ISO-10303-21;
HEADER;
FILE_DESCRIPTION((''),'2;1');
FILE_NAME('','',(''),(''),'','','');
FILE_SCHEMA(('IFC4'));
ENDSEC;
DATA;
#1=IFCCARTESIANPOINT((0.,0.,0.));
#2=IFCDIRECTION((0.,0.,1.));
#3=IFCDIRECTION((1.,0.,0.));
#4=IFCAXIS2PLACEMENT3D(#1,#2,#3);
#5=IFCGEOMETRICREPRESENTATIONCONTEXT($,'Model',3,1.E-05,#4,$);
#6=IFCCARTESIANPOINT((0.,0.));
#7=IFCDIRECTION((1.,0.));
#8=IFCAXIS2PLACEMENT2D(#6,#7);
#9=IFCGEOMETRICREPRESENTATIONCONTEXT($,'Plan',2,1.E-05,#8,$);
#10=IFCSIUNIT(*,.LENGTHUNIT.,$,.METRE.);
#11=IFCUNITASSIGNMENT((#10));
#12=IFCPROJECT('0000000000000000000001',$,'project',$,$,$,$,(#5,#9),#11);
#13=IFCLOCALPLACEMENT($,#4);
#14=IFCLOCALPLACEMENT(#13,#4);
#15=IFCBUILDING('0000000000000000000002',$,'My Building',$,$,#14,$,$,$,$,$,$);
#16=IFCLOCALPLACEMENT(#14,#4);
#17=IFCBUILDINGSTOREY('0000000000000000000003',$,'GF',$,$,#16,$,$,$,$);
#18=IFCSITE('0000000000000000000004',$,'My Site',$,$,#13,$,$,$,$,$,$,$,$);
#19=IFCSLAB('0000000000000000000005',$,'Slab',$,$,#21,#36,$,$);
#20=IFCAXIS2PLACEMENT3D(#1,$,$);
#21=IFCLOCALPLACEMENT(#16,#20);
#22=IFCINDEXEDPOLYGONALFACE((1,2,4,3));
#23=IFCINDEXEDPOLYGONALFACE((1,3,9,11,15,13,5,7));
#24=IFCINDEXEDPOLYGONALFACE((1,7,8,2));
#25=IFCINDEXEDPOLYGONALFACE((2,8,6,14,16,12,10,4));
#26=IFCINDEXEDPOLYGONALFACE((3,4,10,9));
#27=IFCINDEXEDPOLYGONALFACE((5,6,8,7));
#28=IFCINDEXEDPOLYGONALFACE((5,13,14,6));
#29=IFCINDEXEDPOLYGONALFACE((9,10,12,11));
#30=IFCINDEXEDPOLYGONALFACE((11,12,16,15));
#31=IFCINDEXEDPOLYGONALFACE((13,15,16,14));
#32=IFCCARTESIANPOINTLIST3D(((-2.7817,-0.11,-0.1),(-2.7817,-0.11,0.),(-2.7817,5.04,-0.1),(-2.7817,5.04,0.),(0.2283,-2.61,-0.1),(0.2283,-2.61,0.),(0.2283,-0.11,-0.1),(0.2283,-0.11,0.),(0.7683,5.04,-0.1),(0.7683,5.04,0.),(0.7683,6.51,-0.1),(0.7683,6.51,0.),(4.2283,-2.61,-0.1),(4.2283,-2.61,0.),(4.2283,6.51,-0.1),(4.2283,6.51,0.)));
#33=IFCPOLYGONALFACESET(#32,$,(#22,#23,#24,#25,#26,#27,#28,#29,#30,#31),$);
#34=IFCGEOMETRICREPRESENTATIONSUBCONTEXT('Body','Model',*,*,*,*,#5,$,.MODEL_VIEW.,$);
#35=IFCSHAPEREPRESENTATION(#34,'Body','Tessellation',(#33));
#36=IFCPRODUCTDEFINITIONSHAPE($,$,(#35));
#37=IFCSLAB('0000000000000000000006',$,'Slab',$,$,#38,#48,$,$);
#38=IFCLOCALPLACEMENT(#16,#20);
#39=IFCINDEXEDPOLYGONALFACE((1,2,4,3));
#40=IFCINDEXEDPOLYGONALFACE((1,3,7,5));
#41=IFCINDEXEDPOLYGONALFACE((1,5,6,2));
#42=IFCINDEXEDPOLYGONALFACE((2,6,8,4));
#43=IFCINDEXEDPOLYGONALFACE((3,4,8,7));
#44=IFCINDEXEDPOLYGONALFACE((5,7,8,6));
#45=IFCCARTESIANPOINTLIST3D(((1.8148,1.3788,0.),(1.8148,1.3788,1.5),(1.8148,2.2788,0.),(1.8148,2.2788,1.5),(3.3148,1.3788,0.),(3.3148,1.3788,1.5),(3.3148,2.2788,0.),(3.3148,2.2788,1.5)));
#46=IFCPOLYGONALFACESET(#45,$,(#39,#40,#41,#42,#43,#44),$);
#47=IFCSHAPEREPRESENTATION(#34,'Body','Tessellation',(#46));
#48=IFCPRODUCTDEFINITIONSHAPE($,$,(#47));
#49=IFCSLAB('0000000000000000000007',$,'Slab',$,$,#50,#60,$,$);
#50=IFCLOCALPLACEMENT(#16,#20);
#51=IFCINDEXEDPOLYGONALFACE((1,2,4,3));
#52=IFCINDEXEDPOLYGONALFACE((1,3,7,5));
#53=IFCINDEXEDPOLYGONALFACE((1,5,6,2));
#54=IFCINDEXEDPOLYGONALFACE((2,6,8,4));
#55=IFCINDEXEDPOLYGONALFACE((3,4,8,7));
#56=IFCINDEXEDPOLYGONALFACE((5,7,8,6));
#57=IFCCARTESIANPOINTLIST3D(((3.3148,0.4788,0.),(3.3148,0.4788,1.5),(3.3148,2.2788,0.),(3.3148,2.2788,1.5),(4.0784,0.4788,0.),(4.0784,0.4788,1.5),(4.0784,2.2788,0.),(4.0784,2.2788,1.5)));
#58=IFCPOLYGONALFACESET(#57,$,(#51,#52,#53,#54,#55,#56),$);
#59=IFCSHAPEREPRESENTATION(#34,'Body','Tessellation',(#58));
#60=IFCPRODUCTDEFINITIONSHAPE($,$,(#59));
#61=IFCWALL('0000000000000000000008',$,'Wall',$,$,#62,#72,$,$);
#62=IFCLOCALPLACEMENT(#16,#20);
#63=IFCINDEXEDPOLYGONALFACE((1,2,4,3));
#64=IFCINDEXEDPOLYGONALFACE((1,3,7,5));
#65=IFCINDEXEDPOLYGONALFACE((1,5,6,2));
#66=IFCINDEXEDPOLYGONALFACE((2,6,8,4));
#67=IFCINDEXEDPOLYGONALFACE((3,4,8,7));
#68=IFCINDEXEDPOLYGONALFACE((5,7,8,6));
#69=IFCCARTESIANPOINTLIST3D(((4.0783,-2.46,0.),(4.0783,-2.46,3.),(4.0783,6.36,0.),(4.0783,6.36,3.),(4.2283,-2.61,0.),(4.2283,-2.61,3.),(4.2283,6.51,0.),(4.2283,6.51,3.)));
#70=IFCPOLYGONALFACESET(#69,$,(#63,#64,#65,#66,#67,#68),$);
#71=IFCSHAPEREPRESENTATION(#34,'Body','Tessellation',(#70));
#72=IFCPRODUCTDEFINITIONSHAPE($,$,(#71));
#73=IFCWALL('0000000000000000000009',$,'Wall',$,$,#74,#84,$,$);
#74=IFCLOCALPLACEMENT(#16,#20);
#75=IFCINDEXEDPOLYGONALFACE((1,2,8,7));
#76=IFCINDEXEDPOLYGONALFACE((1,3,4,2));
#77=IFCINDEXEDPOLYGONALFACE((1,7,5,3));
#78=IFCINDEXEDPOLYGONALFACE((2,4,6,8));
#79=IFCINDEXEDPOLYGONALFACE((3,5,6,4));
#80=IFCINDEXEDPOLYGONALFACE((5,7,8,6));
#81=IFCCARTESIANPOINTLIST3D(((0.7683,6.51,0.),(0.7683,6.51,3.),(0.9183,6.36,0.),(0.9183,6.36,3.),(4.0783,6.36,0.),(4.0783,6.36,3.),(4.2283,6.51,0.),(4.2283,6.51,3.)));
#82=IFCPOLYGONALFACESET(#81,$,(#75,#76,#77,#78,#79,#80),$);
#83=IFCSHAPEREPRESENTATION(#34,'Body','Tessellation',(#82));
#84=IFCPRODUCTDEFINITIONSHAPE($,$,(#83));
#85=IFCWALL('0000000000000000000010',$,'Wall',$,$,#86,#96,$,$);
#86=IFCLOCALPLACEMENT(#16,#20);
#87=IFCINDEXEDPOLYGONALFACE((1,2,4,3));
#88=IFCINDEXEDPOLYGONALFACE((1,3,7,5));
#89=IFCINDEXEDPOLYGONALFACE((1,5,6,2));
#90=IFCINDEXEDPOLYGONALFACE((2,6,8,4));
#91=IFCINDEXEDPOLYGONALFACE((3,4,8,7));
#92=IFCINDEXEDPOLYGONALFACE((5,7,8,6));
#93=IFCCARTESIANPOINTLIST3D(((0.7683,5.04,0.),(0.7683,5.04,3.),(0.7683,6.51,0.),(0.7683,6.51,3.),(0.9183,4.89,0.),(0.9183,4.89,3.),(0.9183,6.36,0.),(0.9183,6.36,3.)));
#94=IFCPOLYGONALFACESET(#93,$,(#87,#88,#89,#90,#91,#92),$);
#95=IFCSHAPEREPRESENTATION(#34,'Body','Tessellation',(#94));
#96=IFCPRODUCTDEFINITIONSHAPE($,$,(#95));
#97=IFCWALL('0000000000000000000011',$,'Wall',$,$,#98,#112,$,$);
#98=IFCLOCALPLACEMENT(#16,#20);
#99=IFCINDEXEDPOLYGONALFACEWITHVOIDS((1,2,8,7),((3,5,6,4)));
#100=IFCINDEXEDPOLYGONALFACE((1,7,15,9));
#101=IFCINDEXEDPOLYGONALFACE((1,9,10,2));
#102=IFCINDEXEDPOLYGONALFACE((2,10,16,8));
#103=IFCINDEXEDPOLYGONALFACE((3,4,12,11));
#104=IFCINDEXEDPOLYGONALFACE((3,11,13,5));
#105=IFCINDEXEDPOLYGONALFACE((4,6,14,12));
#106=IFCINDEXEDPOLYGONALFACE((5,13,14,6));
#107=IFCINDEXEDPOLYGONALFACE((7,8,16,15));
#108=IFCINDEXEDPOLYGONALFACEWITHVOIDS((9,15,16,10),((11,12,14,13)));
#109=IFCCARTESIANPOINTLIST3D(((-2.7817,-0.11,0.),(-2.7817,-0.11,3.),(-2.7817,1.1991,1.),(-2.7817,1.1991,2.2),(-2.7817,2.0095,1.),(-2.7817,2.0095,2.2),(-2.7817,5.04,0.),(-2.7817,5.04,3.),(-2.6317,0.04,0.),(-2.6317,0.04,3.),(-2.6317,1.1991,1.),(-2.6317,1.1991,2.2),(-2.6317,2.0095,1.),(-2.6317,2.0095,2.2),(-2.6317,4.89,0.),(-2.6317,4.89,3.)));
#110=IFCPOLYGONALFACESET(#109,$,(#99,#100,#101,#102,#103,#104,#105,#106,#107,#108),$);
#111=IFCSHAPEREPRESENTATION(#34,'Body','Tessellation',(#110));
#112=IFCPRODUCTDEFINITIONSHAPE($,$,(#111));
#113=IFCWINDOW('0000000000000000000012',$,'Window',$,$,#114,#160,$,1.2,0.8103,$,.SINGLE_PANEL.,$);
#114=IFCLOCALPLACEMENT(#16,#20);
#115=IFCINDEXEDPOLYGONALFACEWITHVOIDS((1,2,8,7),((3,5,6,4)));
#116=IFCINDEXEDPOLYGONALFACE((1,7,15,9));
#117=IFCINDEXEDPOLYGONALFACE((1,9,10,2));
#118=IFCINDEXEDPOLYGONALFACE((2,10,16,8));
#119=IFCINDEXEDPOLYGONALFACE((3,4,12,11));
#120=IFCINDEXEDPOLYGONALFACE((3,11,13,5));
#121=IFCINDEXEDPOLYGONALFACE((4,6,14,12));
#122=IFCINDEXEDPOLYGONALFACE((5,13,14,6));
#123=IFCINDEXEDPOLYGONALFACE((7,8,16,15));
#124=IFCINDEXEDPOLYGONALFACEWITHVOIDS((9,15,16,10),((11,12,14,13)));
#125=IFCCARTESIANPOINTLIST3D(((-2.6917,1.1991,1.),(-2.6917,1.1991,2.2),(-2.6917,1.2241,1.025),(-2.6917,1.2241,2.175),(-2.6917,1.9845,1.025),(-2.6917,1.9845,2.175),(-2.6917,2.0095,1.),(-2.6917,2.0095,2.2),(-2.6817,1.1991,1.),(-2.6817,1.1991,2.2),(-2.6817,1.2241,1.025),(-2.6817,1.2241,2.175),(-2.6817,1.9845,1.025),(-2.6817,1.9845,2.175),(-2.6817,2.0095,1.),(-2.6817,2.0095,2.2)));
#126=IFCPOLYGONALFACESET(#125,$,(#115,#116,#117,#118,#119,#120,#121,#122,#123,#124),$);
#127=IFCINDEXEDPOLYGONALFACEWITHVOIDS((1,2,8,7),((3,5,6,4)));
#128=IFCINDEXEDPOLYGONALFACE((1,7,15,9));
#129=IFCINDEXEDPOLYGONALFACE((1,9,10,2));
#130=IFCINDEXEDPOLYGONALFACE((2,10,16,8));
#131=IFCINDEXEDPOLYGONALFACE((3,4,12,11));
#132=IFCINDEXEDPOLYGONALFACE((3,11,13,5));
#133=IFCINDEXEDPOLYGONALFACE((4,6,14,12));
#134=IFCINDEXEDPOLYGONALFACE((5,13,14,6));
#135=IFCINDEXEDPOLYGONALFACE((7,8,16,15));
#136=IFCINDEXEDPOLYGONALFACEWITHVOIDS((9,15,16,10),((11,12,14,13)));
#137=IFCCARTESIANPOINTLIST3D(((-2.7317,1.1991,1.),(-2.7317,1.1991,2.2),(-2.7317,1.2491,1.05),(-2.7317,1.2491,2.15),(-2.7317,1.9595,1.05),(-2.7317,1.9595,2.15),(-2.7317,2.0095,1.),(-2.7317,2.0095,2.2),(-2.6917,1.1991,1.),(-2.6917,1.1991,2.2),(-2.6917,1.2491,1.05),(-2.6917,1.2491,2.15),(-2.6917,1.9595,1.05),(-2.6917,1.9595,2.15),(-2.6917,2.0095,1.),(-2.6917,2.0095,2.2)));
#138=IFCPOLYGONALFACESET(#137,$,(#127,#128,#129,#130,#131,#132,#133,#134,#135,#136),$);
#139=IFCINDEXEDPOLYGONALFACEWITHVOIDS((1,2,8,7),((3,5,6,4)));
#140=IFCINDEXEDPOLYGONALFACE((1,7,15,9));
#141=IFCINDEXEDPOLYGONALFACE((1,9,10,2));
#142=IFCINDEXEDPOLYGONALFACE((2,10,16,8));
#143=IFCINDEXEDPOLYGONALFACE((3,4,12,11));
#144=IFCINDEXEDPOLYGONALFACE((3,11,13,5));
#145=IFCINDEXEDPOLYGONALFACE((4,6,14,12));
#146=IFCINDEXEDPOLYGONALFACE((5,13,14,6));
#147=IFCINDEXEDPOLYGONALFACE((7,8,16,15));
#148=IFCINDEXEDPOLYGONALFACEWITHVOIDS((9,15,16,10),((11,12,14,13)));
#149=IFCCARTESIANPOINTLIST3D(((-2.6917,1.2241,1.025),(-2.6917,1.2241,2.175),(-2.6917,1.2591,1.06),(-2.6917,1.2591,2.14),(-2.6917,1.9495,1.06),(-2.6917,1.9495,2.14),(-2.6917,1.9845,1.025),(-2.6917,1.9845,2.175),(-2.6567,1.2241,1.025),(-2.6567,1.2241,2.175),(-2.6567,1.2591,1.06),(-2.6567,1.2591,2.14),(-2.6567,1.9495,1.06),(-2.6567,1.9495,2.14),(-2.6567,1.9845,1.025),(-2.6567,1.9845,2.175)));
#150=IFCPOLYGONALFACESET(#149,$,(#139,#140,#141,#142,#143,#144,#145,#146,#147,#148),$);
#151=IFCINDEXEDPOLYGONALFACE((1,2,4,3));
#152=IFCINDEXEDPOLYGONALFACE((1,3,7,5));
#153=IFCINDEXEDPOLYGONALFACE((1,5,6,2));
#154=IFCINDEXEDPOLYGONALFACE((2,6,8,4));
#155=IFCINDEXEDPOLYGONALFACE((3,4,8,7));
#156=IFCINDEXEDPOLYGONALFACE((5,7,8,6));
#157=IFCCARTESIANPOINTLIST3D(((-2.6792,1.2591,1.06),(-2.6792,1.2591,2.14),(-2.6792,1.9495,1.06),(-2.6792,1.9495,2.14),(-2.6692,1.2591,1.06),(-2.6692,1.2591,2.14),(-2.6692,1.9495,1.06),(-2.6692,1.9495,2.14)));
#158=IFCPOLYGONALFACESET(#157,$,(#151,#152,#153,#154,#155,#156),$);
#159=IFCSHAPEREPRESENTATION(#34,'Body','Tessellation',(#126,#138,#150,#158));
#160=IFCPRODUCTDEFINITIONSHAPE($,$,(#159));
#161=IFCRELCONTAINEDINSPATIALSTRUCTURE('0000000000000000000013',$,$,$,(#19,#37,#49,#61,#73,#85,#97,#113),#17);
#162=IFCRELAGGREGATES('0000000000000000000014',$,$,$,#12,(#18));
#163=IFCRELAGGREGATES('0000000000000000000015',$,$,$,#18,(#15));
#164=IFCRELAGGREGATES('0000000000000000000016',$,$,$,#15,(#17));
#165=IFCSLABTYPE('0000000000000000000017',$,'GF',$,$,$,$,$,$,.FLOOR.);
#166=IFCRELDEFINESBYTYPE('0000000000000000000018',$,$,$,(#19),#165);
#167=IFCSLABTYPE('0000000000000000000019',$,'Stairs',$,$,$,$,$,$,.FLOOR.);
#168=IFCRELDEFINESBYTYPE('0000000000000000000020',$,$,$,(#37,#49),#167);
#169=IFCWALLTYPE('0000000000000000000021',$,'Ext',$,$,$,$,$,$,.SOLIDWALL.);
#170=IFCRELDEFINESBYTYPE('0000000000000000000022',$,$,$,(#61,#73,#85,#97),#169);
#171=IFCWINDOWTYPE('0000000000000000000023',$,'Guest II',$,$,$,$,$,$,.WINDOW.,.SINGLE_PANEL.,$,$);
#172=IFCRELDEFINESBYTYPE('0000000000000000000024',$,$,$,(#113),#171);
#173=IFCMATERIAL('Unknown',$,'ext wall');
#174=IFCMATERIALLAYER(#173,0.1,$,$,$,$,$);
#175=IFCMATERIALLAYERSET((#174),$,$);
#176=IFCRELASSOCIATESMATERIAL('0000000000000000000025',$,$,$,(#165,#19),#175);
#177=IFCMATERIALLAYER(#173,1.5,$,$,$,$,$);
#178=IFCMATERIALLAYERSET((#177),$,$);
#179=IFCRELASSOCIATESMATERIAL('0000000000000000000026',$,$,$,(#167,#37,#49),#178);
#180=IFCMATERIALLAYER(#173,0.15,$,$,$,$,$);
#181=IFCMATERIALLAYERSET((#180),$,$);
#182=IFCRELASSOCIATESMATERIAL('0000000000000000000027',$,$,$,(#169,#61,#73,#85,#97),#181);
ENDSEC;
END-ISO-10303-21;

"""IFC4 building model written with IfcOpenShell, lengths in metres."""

from ifc_helpers import new_model, entity, si_unit, frame, origin_with_axes, origin_2d_with_axis, place, context, subcontext, project, spatial, line, indexed_curve, outline, extrude, shape, source, transform, mapped, material, layer, layer_set, layer_usage, type_object, type_shapes, element, fill, save


model = new_model("IFC4")

# Units and contexts
model_context = context("Model", 3, precision=1e-05, world=origin_with_axes())
plan_context = context("Plan", 2, precision=1e-05, world=origin_2d_with_axis())
body_context_1 = subcontext(model_context, "Body", "Model", "MODEL_VIEW")
body_context_2 = subcontext(plan_context, "Body", "Plan", "PLAN_VIEW")
ifc_project = project(units=[si_unit("LENGTHUNIT", "METRE")], contexts=[model_context, plan_context])

# Site, building, storey
site_placement = place(None, origin_with_axes())
site = spatial("IfcSite", under=ifc_project, at=site_placement, Name="My Site")
building_placement = place(site_placement, origin_with_axes())
building = spatial("IfcBuilding", under=site, at=building_placement, Name="My Building")
storey_placement = place(building_placement, origin_with_axes())
storey = spatial("IfcBuildingStorey", under=building, at=storey_placement, Name="GF")

# Slabs
ifc_material = material(Name="Unknown", Category="ext wall")
ifc_layer_1 = layer(ifc_material, 0.1)
ifc_layer_set_1 = layer_set([ifc_layer_1])
ifc_layer_usage_1 = layer_usage(ifc_layer_set_1, "AXIS3", "POSITIVE", -0.1)
slab_type_1 = type_object("IfcSlabType", Name="GF", PredefinedType="FLOOR", material=ifc_layer_set_1)
slab_1_placement = place(storey_placement, frame((-2.7817, 5.04, 0.0), z_axis=(0.0, 0.0, 1.0), x_axis=(1.0, 0.0, 0.0)))
element("IfcSlab", 1, at=slab_1_placement, inside=storey, type_object=slab_type_1, material=ifc_layer_usage_1, Name="Slab", context=body_context_1, shape_type="SweptSolid", body=[
    extrude(outline(indexed_curve([(0.0, 0.0), (3.55, 0.0), (3.55, 1.47), (7.01, 1.47), (7.01, -7.65), (3.01, -7.65), (3.01, -5.15), (0.0, -5.15), (0.0, 0.0)])), frame((0.0, 0.0, -0.1), z_axis=(0.0, 0.0, 1.0), x_axis=(1.0, 0.0, 0.0)), (0.0, 0.0, 1.0), 0.1),
])
ifc_layer_2 = layer(ifc_material, 1.5)
ifc_layer_set_2 = layer_set([ifc_layer_2])
ifc_layer_usage_2 = layer_usage(ifc_layer_set_2, "AXIS3", "POSITIVE", -1.5)
slab_type_2 = type_object("IfcSlabType", Name="Stairs", PredefinedType="FLOOR", material=ifc_layer_set_2)
slab_2_placement = place(storey_placement, frame((3.3148, 2.2788, 1.5), z_axis=(0.0, 0.0, 1.0), x_axis=(1.0, 0.0, 0.0)))
element("IfcSlab", 2, at=slab_2_placement, inside=storey, type_object=slab_type_2, material=ifc_layer_usage_2, Name="Slab", context=body_context_1, shape_type="SweptSolid", body=[
    extrude(outline(indexed_curve([(0.0, 0.0), (0.0, -0.9), (-1.5, -0.9), (-1.5, 0.0), (0.0, 0.0)])), frame((0.0, 0.0, -1.5), z_axis=(0.0, 0.0, 1.0), x_axis=(1.0, 0.0, 0.0)), (0.0, 0.0, 1.0), 1.5),
])
ifc_layer_usage_3 = layer_usage(ifc_layer_set_2, "AXIS3", "POSITIVE", -1.5)
slab_3_placement = place(storey_placement, frame((3.3148, 0.4788, 1.5), z_axis=(0.0, 0.0, 1.0), x_axis=(1.0, 0.0, 0.0)))
element("IfcSlab", 3, at=slab_3_placement, inside=storey, type_object=slab_type_2, material=ifc_layer_usage_3, Name="Slab", context=body_context_1, shape_type="SweptSolid", body=[
    extrude(outline(indexed_curve([(0.0, 0.0), (0.7636, 0.0), (0.7636, 1.8), (0.0, 1.8), (0.0, 0.0)])), frame((0.0, 0.0, -1.5), z_axis=(0.0, 0.0, 1.0), x_axis=(1.0, 0.0, 0.0)), (0.0, 0.0, 1.0), 1.5),
])

# Shared definitions
ifc_layer_3 = layer(ifc_material, 0.15)
ifc_layer_set_3 = layer_set([ifc_layer_3])
wall_type_1 = type_object("IfcWallType", Name="Ext", PredefinedType="SOLIDWALL", material=ifc_layer_set_3)

# Walls
ifc_layer_usage_4 = layer_usage(ifc_layer_set_3, "AXIS2", "POSITIVE", 0.0)
wall_1_placement = place(storey_placement, frame((4.2283, -2.61, 0.0), z_axis=(0.0, 0.0, 1.0), x_axis=(0.0, 1.0, 0.0)))
element("IfcWall", 4, at=wall_1_placement, inside=storey, type_object=wall_type_1, material=ifc_layer_usage_4, Name="Wall", context=body_context_1, shape_type="SweptSolid", body=[
    extrude(outline(indexed_curve([(0.0, 0.0), (0.15, 0.15), (8.97, 0.15), (9.12, 0.0)], segments=[line(1, 2, 3, 4, 1)])), origin_with_axes(), (0.0, 0.0, 1.0), 3.0),
])
ifc_layer_usage_5 = layer_usage(ifc_layer_set_3, "AXIS2", "POSITIVE", 0.0)
wall_2_placement = place(storey_placement, frame((4.2283, 6.51, 0.0), z_axis=(0.0, 0.0, 1.0), x_axis=(-1.0, 0.0, 0.0)))
element("IfcWall", 5, at=wall_2_placement, inside=storey, type_object=wall_type_1, material=ifc_layer_usage_5, Name="Wall", context=body_context_1, shape_type="SweptSolid", body=[
    extrude(outline(indexed_curve([(0.0, 0.0), (0.15, 0.15), (3.31, 0.15), (3.46, 0.0)], segments=[line(1, 2, 3, 4, 1)])), origin_with_axes(), (0.0, 0.0, 1.0), 3.0),
])
ifc_layer_usage_6 = layer_usage(ifc_layer_set_3, "AXIS2", "POSITIVE", 0.0)
wall_3_placement = place(storey_placement, frame((0.7683, 6.51, 0.0), z_axis=(0.0, 0.0, 1.0), x_axis=(0.0, -1.0, 0.0)))
element("IfcWall", 6, at=wall_3_placement, inside=storey, type_object=wall_type_1, material=ifc_layer_usage_6, Name="Wall", context=body_context_1, shape_type="SweptSolid", body=[
    extrude(outline(indexed_curve([(0.0, 0.0), (0.15, 0.15), (1.62, 0.15), (1.47, 0.0)], segments=[line(1, 2, 3, 4, 1)])), origin_with_axes(), (0.0, 0.0, 1.0), 3.0),
])

# Wall, opening, window
ifc_layer_usage_7 = layer_usage(ifc_layer_set_3, "AXIS2", "POSITIVE", 0.0)
wall_4_placement = place(storey_placement, frame((-2.7817, 5.04, 0.0), z_axis=(0.0, 0.0, 1.0), x_axis=(0.0, -1.0, 0.0)))
wall_4 = element("IfcWall", 7, at=wall_4_placement, inside=storey, type_object=wall_type_1, material=ifc_layer_usage_7, Name="Wall", context=body_context_1, shape_type="SweptSolid", body=[
    extrude(outline(indexed_curve([(0.0, 0.0), (0.15, 0.15), (5.0, 0.15), (5.15, 0.0)], segments=[line(1, 2, 3, 4, 1)])), origin_with_axes(), (0.0, 0.0, 1.0), 3.0),
])
shared_shape_1 = source(origin_with_axes(), body_context_1, "Body", "SweptSolid", [
    extrude(outline(indexed_curve([(0.0, 0.0), (0.8103, 0.0), (0.8103, 1.2), (0.0, 1.2)], segments=[line(1, 2, 3, 4, 1)])), frame((0.0, -0.6, 0.0), z_axis=(0.0, -1.0, 0.0), x_axis=(1.0, 0.0, 0.0)), (0.0, 0.0, -1.0), 1.2),
])
opening_1_placement = place(wall_4_placement, frame((3.0305, 0.0, 1.0), z_axis=(0.0, 0.0, 1.0), x_axis=(1.0, 0.0, 0.0)))
opening_1 = element("IfcOpeningElement", 8, at=opening_1_placement, cuts=wall_4, PredefinedType="OPENING", context=body_context_1, shape_type="MappedRepresentation", body=[
    mapped(shared_shape_1, transform((0.0, 0.0, 0.0), x_axis=(1.0, 0.0, 0.0), y_axis=(0.0, 1.0, 0.0), z_axis=(0.0, 0.0, 1.0), scale=1.0)),
])
window_type_1 = type_object("IfcWindowType", Name="Guest II", PartitioningType="SINGLE_PANEL", PredefinedType="WINDOW")
shared_shape_2 = source(origin_with_axes(), body_context_1, "Body", "SweptSolid", [
    extrude(outline(indexed_curve([(0.0, 0.0), (0.8103, 0.0), (0.8103, 1.2), (0.0, 1.2)], segments=[line(1, 2, 3, 4, 1)]), holes=[indexed_curve([(0.025, 0.025), (0.7853, 0.025), (0.7853, 1.175), (0.025, 1.175)], segments=[line(1, 2, 3, 4, 1)])]), frame((0.0, 0.09, 0.0), z_axis=(0.0, -1.0, 0.0), x_axis=(1.0, 0.0, 0.0)), (0.0, 0.0, -1.0), 0.01),
    extrude(outline(indexed_curve([(0.0, 0.0), (0.8103, 0.0), (0.8103, 1.2), (0.0, 1.2)], segments=[line(1, 2, 3, 4, 1)]), holes=[indexed_curve([(0.05, 0.05), (0.7603, 0.05), (0.7603, 1.15), (0.05, 1.15)], segments=[line(1, 2, 3, 4, 1)])]), frame((0.0, 0.05, 0.0), z_axis=(0.0, -1.0, 0.0), x_axis=(1.0, 0.0, 0.0)), (0.0, 0.0, -1.0), 0.04),
    extrude(outline(indexed_curve([(0.0, 0.0), (0.7603, 0.0), (0.7603, 1.15), (0.0, 1.15)], segments=[line(1, 2, 3, 4, 1)]), holes=[indexed_curve([(0.035, 0.035), (0.7253, 0.035), (0.7253, 1.115), (0.035, 1.115)], segments=[line(1, 2, 3, 4, 1)])]), frame((0.025, 0.09, 0.025), z_axis=(0.0, -1.0, 0.0), x_axis=(1.0, 0.0, 0.0)), (0.0, 0.0, -1.0), 0.035),
    extrude(outline(indexed_curve([(0.035, 0.035), (0.7253, 0.035), (0.7253, 1.115), (0.035, 1.115)], segments=[line(1, 2, 3, 4, 1)])), frame((0.025, 0.1025, 0.025), z_axis=(0.0, -1.0, 0.0), x_axis=(1.0, 0.0, 0.0)), (0.0, 0.0, -1.0), 0.01),
])
shared_shape_3 = source(origin_with_axes(), body_context_2, "Body", "Curve2D", [
    entity("IfcIndexedPolyCurve", entity("IfcCartesianPointList2D", [[0.05, 0.05], [0.7603, 0.05]])),
    entity("IfcIndexedPolyCurve", entity("IfcCartesianPointList2D", [[0.0, 0.1], [0.025, 0.1], [0.025, 0.09], [0.05, 0.09], [0.05, 0.05], [0.0, 0.05]]), [entity("IfcLineIndex", [1, 2, 3, 4, 5, 6, 1])]),
    entity("IfcIndexedPolyCurve", entity("IfcCartesianPointList2D", [[0.8103, 0.1], [0.7853, 0.1], [0.7853, 0.09], [0.7603, 0.09], [0.7603, 0.05], [0.8103, 0.05]]), [entity("IfcLineIndex", [1, 2, 3, 4, 5, 6, 1])]),
    entity("IfcIndexedPolyCurve", entity("IfcCartesianPointList2D", [[0.025, 0.09], [0.06, 0.09], [0.06, 0.125], [0.025, 0.125]]), [entity("IfcLineIndex", [1, 2, 3, 4, 1])]),
    entity("IfcIndexedPolyCurve", entity("IfcCartesianPointList2D", [[0.7853, 0.09], [0.7503, 0.09], [0.7503, 0.125], [0.7853, 0.125]]), [entity("IfcLineIndex", [1, 2, 3, 4, 1])]),
    entity("IfcIndexedPolyCurve", entity("IfcCartesianPointList2D", [[0.06, 0.09], [0.7503, 0.09]])),
    entity("IfcIndexedPolyCurve", entity("IfcCartesianPointList2D", [[0.06, 0.125], [0.7503, 0.125]])),
    entity("IfcIndexedPolyCurve", entity("IfcCartesianPointList2D", [[0.06, 0.1075], [0.7503, 0.1075]])),
])
type_shapes(window_type_1, [shared_shape_2, shared_shape_3])
window_1_placement = place(opening_1_placement, frame((0.0, 0.0, 0.0), z_axis=(0.0, 0.0, 1.0), x_axis=(1.0, 0.0, 0.0)))
window_1 = element("IfcWindow", 9, at=window_1_placement, inside=storey, type_object=window_type_1, Name="Window", OverallHeight=1.2, OverallWidth=0.8103, PartitioningType="SINGLE_PANEL", shapes=[
    shape(body_context_1, "Body", "MappedRepresentation", [mapped(shared_shape_2, transform((0.0, 0.0, 0.0), x_axis=(1.0, 0.0, 0.0), y_axis=(0.0, 1.0, 0.0), z_axis=(0.0, 0.0, 1.0), scale=1.0))]),
    shape(body_context_2, "Body", "MappedRepresentation", [mapped(shared_shape_3, transform((0.0, 0.0, 0.0), x_axis=(1.0, 0.0, 0.0), y_axis=(0.0, 1.0, 0.0), z_axis=(0.0, 0.0, 1.0), scale=1.0))]),
])
fill(opening_1, window_1)

save(model, "model.ifc")
